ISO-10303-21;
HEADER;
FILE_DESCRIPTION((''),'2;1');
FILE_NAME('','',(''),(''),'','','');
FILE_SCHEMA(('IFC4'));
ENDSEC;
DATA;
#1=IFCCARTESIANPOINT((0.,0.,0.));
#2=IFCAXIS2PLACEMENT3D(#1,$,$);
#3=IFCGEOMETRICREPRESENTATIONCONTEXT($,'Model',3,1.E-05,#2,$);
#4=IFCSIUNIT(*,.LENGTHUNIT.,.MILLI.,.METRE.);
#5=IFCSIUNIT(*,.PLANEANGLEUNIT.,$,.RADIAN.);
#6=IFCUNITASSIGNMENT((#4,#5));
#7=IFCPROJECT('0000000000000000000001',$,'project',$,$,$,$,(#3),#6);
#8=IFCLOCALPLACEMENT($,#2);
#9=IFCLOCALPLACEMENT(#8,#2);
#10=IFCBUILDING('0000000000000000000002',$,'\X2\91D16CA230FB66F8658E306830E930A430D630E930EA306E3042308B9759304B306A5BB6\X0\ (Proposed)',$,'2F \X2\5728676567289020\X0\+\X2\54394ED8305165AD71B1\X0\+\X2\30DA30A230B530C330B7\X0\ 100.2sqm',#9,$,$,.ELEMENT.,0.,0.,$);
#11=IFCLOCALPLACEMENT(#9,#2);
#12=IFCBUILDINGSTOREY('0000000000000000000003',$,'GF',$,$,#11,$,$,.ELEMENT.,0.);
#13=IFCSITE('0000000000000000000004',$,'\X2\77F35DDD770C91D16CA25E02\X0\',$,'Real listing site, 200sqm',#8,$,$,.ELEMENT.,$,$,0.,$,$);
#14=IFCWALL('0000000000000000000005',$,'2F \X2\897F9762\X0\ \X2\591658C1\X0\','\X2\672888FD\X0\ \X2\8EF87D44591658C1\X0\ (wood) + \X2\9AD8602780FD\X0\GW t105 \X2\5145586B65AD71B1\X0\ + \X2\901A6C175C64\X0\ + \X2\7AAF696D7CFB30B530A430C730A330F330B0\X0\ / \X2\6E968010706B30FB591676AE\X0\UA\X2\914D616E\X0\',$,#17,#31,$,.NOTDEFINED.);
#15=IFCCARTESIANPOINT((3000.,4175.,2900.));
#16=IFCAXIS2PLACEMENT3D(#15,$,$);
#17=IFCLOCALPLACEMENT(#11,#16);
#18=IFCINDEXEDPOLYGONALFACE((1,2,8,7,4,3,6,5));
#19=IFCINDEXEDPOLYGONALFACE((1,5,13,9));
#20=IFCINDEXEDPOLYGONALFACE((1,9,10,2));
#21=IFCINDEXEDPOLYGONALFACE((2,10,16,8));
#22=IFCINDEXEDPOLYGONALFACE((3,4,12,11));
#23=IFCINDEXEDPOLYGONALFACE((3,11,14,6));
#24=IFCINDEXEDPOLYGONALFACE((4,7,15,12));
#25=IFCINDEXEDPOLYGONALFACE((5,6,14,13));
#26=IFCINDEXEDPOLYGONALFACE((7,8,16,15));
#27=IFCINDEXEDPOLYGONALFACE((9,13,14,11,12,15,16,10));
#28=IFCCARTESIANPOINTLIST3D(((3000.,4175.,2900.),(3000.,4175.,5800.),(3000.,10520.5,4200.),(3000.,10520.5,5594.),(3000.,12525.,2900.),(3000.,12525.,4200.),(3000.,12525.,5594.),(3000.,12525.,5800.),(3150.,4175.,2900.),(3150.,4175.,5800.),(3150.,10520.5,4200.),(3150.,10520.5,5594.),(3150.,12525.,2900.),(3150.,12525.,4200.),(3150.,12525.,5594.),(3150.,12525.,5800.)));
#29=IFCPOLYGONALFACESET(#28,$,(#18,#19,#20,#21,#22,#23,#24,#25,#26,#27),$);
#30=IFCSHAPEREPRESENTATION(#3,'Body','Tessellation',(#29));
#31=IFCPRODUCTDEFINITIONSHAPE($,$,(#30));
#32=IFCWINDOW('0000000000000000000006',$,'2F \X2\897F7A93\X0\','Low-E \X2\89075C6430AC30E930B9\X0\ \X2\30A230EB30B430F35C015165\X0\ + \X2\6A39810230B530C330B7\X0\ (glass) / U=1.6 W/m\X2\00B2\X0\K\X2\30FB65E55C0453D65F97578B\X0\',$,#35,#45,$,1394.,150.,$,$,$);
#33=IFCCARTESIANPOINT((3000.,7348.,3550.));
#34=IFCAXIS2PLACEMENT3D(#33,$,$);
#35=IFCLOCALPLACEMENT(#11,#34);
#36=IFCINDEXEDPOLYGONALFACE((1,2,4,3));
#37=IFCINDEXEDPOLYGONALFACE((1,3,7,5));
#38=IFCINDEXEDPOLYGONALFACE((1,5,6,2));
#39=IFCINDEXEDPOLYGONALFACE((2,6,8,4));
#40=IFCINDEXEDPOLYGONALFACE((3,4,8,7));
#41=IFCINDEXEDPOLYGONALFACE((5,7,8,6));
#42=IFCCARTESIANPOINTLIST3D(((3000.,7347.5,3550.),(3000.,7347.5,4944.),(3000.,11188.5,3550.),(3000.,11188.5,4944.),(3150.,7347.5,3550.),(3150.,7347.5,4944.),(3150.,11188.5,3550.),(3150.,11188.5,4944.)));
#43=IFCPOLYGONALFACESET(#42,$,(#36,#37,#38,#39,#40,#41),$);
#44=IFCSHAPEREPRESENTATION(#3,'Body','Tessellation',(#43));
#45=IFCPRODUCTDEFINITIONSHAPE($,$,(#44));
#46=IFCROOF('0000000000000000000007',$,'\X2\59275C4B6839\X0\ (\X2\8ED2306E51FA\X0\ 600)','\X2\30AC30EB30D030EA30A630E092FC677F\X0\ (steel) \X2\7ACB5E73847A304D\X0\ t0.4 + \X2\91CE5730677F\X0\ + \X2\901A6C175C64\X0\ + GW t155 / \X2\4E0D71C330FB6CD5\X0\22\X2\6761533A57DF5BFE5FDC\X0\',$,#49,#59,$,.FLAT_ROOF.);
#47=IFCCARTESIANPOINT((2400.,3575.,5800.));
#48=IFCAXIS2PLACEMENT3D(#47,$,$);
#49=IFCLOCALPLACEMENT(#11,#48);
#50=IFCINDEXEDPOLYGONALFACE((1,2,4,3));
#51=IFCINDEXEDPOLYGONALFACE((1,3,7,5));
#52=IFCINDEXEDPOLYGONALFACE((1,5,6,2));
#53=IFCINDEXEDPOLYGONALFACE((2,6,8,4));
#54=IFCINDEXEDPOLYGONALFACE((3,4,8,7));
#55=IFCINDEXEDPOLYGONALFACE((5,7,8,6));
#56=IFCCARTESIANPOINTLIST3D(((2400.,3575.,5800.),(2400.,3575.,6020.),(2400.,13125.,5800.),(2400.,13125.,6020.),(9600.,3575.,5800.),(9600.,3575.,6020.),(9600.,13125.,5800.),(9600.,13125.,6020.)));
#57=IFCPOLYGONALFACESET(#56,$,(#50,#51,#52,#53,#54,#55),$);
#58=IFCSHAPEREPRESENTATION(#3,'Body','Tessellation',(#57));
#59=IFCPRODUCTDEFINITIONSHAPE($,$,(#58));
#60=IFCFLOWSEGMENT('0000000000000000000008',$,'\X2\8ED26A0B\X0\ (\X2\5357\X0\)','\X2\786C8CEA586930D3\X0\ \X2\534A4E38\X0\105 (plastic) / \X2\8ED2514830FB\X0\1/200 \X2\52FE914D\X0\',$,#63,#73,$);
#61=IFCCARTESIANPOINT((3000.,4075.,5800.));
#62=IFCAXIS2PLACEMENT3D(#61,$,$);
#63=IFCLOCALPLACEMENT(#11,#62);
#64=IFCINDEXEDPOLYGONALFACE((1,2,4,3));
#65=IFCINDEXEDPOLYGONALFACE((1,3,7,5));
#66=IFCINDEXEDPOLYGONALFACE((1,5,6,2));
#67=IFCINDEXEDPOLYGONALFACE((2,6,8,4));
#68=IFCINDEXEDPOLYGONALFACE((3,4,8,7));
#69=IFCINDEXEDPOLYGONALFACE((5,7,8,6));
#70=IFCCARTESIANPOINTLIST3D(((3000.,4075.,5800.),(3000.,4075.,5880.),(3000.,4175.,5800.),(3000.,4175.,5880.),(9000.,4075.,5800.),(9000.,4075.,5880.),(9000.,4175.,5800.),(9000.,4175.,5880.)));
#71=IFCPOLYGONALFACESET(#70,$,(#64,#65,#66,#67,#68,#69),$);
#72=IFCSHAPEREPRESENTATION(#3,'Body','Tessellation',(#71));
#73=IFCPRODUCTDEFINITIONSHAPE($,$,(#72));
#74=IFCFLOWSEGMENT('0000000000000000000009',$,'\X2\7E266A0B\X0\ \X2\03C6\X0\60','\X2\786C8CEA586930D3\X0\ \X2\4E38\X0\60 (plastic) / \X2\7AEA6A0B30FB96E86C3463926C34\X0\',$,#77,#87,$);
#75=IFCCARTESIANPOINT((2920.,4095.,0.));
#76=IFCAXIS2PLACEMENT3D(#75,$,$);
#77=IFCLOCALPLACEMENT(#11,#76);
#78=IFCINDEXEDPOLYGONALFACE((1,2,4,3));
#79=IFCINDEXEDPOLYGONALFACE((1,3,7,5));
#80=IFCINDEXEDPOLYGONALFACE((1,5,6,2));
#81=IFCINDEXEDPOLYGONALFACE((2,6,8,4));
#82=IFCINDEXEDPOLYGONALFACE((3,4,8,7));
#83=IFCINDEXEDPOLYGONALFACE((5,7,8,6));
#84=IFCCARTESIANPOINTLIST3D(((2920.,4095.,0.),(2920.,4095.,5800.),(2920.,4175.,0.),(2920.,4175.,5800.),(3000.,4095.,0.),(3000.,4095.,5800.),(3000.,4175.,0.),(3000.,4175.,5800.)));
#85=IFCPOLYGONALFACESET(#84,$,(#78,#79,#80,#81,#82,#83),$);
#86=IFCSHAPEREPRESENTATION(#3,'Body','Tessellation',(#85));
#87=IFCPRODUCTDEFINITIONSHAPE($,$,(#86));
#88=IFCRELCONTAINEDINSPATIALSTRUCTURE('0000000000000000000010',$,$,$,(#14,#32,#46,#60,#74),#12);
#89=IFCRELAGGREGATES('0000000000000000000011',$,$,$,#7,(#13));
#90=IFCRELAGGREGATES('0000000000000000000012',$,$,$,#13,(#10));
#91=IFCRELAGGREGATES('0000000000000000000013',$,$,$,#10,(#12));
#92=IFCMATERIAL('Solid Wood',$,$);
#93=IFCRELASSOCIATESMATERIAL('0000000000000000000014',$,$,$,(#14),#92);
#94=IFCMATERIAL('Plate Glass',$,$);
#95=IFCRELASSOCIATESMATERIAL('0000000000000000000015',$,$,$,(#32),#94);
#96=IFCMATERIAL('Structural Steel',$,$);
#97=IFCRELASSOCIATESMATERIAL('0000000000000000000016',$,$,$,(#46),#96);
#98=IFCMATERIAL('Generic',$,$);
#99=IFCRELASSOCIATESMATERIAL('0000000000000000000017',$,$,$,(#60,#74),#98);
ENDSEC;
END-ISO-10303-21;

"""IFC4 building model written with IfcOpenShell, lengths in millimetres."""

from ifc_helpers import new_model, si_unit, frame, frame_2d, origin, place, context, project, spatial, rectangle, extrude, material, element, fill, save


model = new_model("IFC4")

# Units and contexts
model_context = context("Model", 3, precision=1e-05, world=origin())
ifc_project = project(units=[si_unit("LENGTHUNIT", "METRE", prefix="MILLI"), si_unit("PLANEANGLEUNIT", "RADIAN")], contexts=[model_context])

# Site, building, storey
site_placement = place(None, origin())
site = spatial("IfcSite", under=ifc_project, at=site_placement, Name="石川県金沢市", ObjectType="Real listing site, 200sqm", CompositionType="ELEMENT", RefElevation=0.0)
building_placement = place(site_placement, origin())
building = spatial("IfcBuilding", under=site, at=building_placement, Name="金沢・書斎とライブラリのある静かな家 (Proposed)", ObjectType="2F 在来木造+吹付け断熱+ペアサッシ 100.2sqm", CompositionType="ELEMENT", ElevationOfRefHeight=0.0, ElevationOfTerrain=0.0)
storey_placement = place(building_placement, origin())
storey = spatial("IfcBuildingStorey", under=building, at=storey_placement, Name="GF", CompositionType="ELEMENT", Elevation=0.0)

# Shared definitions
ifc_material_1 = material(Name="Solid Wood")

# Shared definitions
ifc_material_2 = material(Name="Plate Glass")

# Wall, opening, window
wall_1_placement = place(storey_placement, frame((3000.0, 4175.0, 2900.0)))
wall_1 = element("IfcWall", 1, at=wall_1_placement, inside=storey, material=ifc_material_1, Name="2F 西面 外壁", Description="木製 軸組外壁 (wood) + 高性能GW t105 充填断熱 + 通気層 + 窯業系サイディング / 準耐火・外皮UA配慮", PredefinedType="NOTDEFINED", context=model_context, shape_type="SweptSolid", body=[
    extrude(rectangle(XDim=150.0, YDim=8350.0, at=frame_2d((75.0, 4175.0))), frame((3000.0, 4175.0, 2900.0)), (0.0, 0.0, 1.0), 2900.0),
])
opening_1_placement = place(storey_placement, frame((3000.0, 7348.0, 3550.0)))
opening_1 = element("IfcOpeningElement", 2, at=opening_1_placement, cuts=wall_1, PredefinedType="NOTDEFINED", context=model_context, shape_type="SweptSolid", body=[
    extrude(rectangle(XDim=150.0, YDim=3841.0, at=frame_2d((75.0, 1920.0))), frame((3000.0, 7348.0, 3550.0)), (0.0, 0.0, 1.0), 1394.0),
])
window_1_placement = place(storey_placement, frame((3000.0, 7348.0, 3550.0)))
window_1 = element("IfcWindow", 3, at=window_1_placement, inside=storey, material=ifc_material_2, Name="2F 西窓", Description="Low-E 複層ガラス アルゴン封入 + 樹脂サッシ (glass) / U=1.6 W/m²K・日射取得型", OverallHeight=1394.0, OverallWidth=150.0, context=model_context, shape_type="SweptSolid", body=[
    extrude(rectangle(XDim=150.0, YDim=3841.0, at=frame_2d((75.0, 1920.0))), frame((3000.0, 7348.0, 3550.0)), (0.0, 0.0, 1.0), 1394.0),
])
fill(opening_1, window_1)

# Roof
ifc_material_3 = material(Name="Structural Steel")
roof_placement = place(storey_placement, frame((2400.0, 3575.0, 5800.0)))
element("IfcRoof", 4, at=roof_placement, inside=storey, material=ifc_material_3, Name="大屋根 (軒の出 600)", Description="ガルバリウム鋼板 (steel) 立平葺き t0.4 + 野地板 + 通気層 + GW t155 / 不燃・法22条区域対応", PredefinedType="FLAT_ROOF", context=model_context, shape_type="SweptSolid", body=[
    extrude(rectangle(XDim=7200.0, YDim=9550.0, at=frame_2d((3600.0, 4775.0))), frame((2400.0, 3575.0, 5800.0)), (0.0, 0.0, 1.0), 220.0),
])

# Flow segments
ifc_material_4 = material(Name="Generic")
flow_segment_1_placement = place(storey_placement, frame((3000.0, 4075.0, 5800.0)))
element("IfcFlowSegment", 5, at=flow_segment_1_placement, inside=storey, material=ifc_material_4, Name="軒樋 (南)", Description="硬質塩ビ 半丸105 (plastic) / 軒先・1/200 勾配", context=model_context, shape_type="SweptSolid", body=[
    extrude(rectangle(XDim=6000.0, YDim=100.0, at=frame_2d((3000.0, 50.0))), frame((3000.0, 4075.0, 5800.0)), (0.0, 0.0, 1.0), 80.0),
])
flow_segment_2_placement = place(storey_placement, frame((2920.0, 4095.0, 0.0)))
element("IfcFlowSegment", 6, at=flow_segment_2_placement, inside=storey, material=ifc_material_4, Name="縦樋 φ60", Description="硬質塩ビ 丸60 (plastic) / 竪樋・雨水排水", context=model_context, shape_type="SweptSolid", body=[
    extrude(rectangle(XDim=80.0, YDim=80.0, at=frame_2d((40.0, 40.0))), frame((2920.0, 4095.0, 0.0)), (0.0, 0.0, 1.0), 5800.0),
])

save(model, "model.ifc")
